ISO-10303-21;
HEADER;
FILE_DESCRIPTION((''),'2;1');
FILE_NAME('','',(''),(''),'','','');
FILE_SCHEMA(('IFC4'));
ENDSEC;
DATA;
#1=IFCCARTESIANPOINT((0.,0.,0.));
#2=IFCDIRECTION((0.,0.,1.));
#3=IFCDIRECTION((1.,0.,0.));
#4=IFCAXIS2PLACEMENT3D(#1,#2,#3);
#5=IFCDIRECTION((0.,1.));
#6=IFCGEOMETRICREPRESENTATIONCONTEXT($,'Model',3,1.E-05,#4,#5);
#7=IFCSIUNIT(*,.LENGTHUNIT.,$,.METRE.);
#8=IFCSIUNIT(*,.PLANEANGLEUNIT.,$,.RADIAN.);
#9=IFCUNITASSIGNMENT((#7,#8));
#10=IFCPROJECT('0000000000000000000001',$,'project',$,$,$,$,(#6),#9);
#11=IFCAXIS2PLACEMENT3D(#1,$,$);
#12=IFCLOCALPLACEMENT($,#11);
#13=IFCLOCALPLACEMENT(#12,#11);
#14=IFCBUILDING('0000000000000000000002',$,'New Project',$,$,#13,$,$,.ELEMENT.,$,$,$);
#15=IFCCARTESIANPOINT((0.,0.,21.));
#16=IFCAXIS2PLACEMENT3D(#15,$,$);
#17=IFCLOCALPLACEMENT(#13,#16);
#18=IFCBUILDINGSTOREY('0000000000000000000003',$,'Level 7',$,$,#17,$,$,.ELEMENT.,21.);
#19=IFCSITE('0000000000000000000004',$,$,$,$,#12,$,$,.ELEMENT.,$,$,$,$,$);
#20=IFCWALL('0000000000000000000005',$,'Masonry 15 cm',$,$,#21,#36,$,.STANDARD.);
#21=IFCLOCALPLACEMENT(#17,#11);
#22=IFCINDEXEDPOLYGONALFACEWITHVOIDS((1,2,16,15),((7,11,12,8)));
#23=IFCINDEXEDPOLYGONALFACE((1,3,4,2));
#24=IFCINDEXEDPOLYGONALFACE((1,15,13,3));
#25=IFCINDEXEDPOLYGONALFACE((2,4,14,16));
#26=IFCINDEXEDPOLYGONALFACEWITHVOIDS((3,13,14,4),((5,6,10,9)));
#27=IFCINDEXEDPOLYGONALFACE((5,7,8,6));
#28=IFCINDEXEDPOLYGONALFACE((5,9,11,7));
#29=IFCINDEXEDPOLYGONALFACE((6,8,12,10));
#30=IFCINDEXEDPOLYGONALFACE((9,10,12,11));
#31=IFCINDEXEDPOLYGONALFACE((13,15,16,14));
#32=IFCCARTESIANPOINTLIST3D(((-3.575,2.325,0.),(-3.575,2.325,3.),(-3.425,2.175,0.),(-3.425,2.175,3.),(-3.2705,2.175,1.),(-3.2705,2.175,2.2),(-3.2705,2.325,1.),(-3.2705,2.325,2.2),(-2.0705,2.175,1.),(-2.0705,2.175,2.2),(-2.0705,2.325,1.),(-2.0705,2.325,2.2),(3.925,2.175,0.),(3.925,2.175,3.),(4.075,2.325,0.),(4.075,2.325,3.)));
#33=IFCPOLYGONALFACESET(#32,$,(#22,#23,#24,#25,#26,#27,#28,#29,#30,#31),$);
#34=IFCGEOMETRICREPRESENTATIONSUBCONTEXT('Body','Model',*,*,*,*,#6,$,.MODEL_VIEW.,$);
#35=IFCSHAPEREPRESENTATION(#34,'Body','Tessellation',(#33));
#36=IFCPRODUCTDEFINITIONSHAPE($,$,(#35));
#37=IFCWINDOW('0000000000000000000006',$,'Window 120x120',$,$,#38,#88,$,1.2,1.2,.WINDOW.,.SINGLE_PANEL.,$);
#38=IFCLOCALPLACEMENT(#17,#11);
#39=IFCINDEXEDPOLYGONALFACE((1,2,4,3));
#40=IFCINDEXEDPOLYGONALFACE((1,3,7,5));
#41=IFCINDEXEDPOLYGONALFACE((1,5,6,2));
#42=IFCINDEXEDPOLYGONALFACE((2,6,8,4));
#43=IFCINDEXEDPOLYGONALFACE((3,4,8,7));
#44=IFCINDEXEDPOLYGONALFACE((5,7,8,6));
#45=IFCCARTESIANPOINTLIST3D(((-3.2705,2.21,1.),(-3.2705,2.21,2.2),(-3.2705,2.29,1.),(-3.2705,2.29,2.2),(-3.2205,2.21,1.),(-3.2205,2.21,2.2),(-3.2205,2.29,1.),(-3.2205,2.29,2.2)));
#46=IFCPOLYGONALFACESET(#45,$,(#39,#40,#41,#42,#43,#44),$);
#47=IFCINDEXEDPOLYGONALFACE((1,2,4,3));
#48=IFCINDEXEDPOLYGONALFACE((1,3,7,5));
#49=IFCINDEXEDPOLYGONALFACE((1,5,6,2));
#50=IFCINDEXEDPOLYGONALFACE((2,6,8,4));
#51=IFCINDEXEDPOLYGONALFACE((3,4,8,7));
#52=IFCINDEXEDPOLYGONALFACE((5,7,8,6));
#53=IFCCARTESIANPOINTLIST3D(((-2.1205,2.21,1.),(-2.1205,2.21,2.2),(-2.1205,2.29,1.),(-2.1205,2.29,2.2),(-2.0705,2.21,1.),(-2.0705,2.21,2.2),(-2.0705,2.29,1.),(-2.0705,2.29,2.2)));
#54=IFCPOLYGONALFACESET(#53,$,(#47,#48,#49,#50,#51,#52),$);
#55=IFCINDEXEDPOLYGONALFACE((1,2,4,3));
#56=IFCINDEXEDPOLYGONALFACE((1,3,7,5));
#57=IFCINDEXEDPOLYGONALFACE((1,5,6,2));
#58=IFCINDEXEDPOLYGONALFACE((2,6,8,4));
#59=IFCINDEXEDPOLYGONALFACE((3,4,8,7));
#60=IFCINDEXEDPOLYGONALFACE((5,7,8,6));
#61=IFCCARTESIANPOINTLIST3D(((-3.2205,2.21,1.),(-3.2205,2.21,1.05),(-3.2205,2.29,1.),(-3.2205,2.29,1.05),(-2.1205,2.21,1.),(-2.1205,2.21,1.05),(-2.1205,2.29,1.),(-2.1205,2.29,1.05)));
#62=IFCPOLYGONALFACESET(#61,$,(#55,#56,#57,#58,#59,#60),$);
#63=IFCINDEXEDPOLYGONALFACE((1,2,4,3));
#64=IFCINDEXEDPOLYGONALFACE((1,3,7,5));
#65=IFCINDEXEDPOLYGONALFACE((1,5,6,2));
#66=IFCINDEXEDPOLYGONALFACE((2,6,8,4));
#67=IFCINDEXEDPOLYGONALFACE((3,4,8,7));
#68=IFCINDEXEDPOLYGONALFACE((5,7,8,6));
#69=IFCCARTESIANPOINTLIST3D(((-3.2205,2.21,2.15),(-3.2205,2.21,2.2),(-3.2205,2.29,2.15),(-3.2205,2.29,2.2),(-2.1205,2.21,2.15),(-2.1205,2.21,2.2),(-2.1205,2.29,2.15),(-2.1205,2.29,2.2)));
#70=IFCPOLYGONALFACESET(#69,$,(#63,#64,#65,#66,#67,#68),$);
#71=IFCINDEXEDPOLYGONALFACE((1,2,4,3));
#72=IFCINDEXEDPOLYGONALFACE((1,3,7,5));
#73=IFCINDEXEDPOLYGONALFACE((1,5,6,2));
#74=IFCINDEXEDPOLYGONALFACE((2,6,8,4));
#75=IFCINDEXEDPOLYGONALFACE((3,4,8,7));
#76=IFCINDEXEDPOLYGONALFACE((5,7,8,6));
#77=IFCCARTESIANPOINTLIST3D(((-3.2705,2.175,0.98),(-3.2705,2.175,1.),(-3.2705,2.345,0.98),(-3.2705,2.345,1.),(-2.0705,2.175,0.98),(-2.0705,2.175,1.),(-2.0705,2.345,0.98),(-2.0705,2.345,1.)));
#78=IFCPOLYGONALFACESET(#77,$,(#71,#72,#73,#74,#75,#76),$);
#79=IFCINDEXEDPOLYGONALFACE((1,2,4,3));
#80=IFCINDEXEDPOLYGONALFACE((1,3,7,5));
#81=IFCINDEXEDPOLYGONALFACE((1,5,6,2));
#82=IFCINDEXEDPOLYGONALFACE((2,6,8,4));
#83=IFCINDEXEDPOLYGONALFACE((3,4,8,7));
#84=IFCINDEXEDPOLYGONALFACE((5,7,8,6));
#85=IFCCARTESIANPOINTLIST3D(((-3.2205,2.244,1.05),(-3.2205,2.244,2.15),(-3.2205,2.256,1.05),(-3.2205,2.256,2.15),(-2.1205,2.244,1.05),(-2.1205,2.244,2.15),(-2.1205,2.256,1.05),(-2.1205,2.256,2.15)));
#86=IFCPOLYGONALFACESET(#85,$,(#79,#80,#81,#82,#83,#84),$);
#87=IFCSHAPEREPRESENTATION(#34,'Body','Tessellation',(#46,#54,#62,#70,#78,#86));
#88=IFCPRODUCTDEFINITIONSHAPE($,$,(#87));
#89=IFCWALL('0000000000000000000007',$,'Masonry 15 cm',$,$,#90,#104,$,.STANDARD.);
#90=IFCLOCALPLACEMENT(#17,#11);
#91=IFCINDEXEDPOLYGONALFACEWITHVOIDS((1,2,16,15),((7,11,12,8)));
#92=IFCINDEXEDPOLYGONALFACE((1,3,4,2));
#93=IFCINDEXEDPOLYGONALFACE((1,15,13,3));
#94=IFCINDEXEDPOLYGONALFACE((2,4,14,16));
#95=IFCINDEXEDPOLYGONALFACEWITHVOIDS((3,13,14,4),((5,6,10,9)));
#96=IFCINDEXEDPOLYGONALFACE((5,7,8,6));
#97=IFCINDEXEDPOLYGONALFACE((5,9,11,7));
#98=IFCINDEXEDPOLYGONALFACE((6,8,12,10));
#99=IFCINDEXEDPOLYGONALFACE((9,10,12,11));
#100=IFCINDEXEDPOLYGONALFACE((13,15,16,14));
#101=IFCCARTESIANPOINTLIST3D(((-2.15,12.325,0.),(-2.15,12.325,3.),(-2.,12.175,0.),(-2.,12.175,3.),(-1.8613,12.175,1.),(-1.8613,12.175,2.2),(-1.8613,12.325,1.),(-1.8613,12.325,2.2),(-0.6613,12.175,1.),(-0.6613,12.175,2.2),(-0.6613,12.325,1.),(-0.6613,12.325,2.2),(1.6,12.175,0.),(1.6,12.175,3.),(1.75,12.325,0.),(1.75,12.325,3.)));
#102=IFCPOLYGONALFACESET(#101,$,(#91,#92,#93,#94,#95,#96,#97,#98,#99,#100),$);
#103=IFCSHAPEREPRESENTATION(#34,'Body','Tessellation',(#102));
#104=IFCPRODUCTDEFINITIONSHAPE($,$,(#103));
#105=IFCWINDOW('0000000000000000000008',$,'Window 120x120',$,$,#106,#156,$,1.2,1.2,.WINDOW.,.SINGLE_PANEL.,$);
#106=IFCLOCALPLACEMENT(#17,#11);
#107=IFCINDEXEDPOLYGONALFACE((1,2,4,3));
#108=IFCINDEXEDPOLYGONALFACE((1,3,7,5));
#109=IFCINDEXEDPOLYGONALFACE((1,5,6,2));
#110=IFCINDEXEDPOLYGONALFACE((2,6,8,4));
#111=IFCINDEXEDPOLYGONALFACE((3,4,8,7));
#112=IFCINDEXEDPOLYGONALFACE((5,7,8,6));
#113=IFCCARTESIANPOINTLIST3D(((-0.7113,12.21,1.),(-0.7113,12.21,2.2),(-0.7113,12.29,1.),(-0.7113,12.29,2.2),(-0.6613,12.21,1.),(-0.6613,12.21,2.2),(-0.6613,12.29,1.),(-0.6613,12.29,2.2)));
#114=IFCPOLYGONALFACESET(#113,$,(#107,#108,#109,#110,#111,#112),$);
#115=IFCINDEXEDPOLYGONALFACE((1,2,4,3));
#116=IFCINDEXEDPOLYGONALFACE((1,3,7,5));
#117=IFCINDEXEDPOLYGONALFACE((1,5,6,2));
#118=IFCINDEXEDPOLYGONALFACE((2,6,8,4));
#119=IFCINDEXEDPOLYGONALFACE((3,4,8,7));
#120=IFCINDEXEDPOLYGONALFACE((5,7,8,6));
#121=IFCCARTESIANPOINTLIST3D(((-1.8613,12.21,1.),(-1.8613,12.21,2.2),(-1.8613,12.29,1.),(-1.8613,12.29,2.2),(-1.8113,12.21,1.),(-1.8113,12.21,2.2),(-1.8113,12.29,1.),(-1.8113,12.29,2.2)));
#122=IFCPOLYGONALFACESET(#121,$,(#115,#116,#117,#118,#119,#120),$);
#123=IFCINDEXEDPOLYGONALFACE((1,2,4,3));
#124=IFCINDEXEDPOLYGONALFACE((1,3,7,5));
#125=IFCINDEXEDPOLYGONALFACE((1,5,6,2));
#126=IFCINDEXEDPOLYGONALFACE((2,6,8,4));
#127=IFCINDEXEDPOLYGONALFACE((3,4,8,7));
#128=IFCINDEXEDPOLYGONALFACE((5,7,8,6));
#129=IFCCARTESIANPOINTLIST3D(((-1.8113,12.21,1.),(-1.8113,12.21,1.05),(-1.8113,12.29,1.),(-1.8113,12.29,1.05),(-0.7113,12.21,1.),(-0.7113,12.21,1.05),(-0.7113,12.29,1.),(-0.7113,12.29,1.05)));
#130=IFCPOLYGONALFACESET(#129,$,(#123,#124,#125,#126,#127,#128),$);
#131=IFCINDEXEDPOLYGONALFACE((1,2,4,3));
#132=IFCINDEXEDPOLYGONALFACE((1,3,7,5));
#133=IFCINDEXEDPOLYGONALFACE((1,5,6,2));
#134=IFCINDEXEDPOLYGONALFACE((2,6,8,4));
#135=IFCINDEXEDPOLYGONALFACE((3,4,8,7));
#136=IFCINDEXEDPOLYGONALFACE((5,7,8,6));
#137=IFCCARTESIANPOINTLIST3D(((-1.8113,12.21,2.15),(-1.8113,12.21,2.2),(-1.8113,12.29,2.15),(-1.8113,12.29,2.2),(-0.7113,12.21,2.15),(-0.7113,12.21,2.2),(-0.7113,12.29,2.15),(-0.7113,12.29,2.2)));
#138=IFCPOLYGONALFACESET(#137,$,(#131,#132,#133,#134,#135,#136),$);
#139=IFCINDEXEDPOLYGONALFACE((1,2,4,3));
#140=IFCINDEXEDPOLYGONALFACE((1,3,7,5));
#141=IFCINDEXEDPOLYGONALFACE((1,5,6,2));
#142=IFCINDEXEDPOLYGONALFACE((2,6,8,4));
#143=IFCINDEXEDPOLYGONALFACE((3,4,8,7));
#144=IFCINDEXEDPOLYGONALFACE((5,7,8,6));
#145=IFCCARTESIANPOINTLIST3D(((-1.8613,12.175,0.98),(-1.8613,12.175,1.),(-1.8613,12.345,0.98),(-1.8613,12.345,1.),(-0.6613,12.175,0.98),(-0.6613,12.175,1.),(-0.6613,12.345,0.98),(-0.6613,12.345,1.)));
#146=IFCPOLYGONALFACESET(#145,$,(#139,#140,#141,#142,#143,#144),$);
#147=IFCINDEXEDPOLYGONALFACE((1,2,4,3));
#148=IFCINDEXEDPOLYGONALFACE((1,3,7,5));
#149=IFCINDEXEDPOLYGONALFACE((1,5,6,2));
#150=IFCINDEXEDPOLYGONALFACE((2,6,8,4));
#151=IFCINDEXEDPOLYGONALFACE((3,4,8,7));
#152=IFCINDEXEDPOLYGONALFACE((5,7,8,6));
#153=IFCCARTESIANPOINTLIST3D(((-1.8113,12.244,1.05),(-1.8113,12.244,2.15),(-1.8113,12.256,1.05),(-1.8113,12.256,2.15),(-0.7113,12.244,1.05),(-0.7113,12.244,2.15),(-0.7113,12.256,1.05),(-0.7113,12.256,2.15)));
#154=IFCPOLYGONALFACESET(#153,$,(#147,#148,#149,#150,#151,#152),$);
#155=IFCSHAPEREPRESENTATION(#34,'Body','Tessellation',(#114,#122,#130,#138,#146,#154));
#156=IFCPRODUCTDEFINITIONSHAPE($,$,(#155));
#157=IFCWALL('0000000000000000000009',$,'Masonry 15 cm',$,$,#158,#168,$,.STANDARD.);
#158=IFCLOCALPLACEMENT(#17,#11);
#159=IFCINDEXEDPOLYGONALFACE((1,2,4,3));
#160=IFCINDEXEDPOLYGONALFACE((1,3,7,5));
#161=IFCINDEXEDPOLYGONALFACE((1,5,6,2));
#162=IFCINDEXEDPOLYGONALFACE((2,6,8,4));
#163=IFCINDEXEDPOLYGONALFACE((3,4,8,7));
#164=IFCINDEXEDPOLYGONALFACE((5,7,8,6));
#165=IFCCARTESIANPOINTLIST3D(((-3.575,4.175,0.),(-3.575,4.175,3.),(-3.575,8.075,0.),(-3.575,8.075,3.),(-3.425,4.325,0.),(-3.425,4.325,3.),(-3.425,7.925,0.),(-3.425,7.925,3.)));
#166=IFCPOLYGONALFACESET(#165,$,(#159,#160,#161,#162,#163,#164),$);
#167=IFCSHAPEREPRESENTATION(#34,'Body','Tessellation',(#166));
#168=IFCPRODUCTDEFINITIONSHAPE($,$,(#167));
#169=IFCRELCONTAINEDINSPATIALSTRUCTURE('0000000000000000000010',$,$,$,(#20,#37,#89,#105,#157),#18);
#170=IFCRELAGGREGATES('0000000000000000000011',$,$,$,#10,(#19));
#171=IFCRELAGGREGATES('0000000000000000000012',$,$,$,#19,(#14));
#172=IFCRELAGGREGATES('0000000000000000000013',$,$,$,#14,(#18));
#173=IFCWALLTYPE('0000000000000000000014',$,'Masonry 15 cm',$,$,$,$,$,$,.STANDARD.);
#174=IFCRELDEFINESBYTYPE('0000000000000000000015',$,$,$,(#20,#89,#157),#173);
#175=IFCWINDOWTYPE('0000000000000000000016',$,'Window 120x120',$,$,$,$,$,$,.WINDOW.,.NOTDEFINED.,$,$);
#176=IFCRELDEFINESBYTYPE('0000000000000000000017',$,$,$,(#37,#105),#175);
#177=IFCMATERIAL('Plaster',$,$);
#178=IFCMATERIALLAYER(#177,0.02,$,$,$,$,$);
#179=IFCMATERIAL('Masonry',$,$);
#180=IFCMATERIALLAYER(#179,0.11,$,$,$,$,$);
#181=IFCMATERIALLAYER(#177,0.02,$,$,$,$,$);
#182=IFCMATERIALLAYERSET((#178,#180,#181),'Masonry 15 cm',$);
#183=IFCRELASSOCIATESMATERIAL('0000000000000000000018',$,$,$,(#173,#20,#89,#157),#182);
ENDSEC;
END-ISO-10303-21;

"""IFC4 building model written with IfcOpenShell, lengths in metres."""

from ifc_helpers import new_model, si_unit, direction, frame, frame_2d, origin, origin_with_axes, place, context, subcontext, project, spatial, polyline, rectangle, outline, extrude, material, layer, layer_set, layer_usage, type_object, element, fill, save


model = new_model("IFC4")

# Units and contexts
model_context = context("Model", 3, precision=1e-05, world=origin_with_axes(), true_north=direction((0.0, 1.0)))
body_context = subcontext(model_context, "Body", "Model", "MODEL_VIEW")
ifc_project = project(units=[si_unit("LENGTHUNIT", "METRE"), si_unit("PLANEANGLEUNIT", "RADIAN")], contexts=[model_context])

# Site, building, storey
site_placement = place(None, origin())
site = spatial("IfcSite", under=ifc_project, at=site_placement, CompositionType="ELEMENT")
building_placement = place(site_placement, origin())
building = spatial("IfcBuilding", under=site, at=building_placement, Name="New Project", CompositionType="ELEMENT")
storey_placement = place(building_placement, frame((0.0, 0.0, 21.0)))
storey = spatial("IfcBuildingStorey", under=building, at=storey_placement, Name="Level 7", CompositionType="ELEMENT", Elevation=21.0)

# Walls, openings, windows
ifc_material_1 = material(Name="Plaster")
ifc_layer_1 = layer(ifc_material_1, 0.02)
ifc_material_2 = material(Name="Masonry")
ifc_layer_2 = layer(ifc_material_2, 0.11)
ifc_layer_3 = layer(ifc_material_1, 0.02)
ifc_layer_set_1 = layer_set([ifc_layer_1, ifc_layer_2, ifc_layer_3], Name="Masonry 15 cm")
ifc_layer_usage_1 = layer_usage(ifc_layer_set_1, "AXIS2", "NEGATIVE", 0.075)
wall_type = type_object("IfcWallType", Name="Masonry 15 cm", PredefinedType="STANDARD", material=ifc_layer_set_1)
wall_1_placement = place(storey_placement, frame((-3.5, 2.25, 0.0)))
wall_1 = element("IfcWall", 1, at=wall_1_placement, inside=storey, type_object=wall_type, material=ifc_layer_usage_1, Name="Masonry 15 cm", PredefinedType="STANDARD", context=body_context, shape_type="SweptSolid", body=[
    extrude(outline(polyline([(0.075, -0.075), (7.425, -0.075), (7.575, 0.075), (-0.075, 0.075), (0.075, -0.075)])), origin(), (0.0, 0.0, 1.0), 3.0),
])
opening_1_placement = place(wall_1_placement, frame((0.2295, 0.0, 1.0)))
opening_1 = element("IfcOpeningElement", 2, at=opening_1_placement, cuts=wall_1, PredefinedType="OPENING", context=body_context, shape_type="SweptSolid", body=[
    extrude(rectangle(XDim=1.2, YDim=0.25, at=frame_2d((0.6, 0.0))), origin(), (0.0, 0.0, 1.0), 1.2),
])
window_type = type_object("IfcWindowType", Name="Window 120x120", PartitioningType="NOTDEFINED", PredefinedType="WINDOW")
window_1_placement = place(opening_1_placement, origin())
window_1 = element("IfcWindow", 3, at=window_1_placement, inside=storey, type_object=window_type, Name="Window 120x120", OverallHeight=1.2, OverallWidth=1.2, PartitioningType="SINGLE_PANEL", PredefinedType="WINDOW", context=body_context, shape_type="SweptSolid", body=[
    extrude(outline(polyline([(0.0, -0.04), (0.05, -0.04), (0.05, 0.04), (0.0, 0.04), (0.0, -0.04)])), origin(), (0.0, 0.0, 1.0), 1.2),
    extrude(outline(polyline([(1.15, -0.04), (1.2, -0.04), (1.2, 0.04), (1.15, 0.04), (1.15, -0.04)])), origin(), (0.0, 0.0, 1.0), 1.2),
    extrude(outline(polyline([(0.05, -0.04), (1.15, -0.04), (1.15, 0.04), (0.05, 0.04), (0.05, -0.04)])), origin(), (0.0, 0.0, 1.0), 0.05),
    extrude(outline(polyline([(0.05, -0.04), (1.15, -0.04), (1.15, 0.04), (0.05, 0.04), (0.05, -0.04)])), frame((0.0, 0.0, 1.15)), (0.0, 0.0, 1.0), 0.05),
    extrude(outline(polyline([(0.0, -0.075), (1.2, -0.075), (1.2, 0.095), (0.0, 0.095), (0.0, -0.075)])), frame((0.0, 0.0, -0.02)), (0.0, 0.0, 1.0), 0.02),
    extrude(outline(polyline([(0.05, -0.006), (1.15, -0.006), (1.15, 0.006), (0.05, 0.006), (0.05, -0.006)])), frame((0.0, 0.0, 0.05)), (0.0, 0.0, 1.0), 1.1),
])
fill(opening_1, window_1)
wall_2_placement = place(storey_placement, frame((-2.075, 12.25, 0.0)))
wall_2 = element("IfcWall", 4, at=wall_2_placement, inside=storey, type_object=wall_type, material=ifc_layer_usage_1, Name="Masonry 15 cm", PredefinedType="STANDARD", context=body_context, shape_type="SweptSolid", body=[
    extrude(outline(polyline([(0.075, -0.075), (3.675, -0.075), (3.825, 0.075), (-0.075, 0.075), (0.075, -0.075)])), origin(), (0.0, 0.0, 1.0), 3.0),
])
opening_2_placement = place(wall_2_placement, frame((0.2137, 0.0, 1.0)))
opening_2 = element("IfcOpeningElement", 5, at=opening_2_placement, cuts=wall_2, PredefinedType="OPENING", context=body_context, shape_type="SweptSolid", body=[
    extrude(rectangle(XDim=1.2, YDim=0.25, at=frame_2d((0.6, 0.0))), origin(), (0.0, 0.0, 1.0), 1.2),
])
window_2_placement = place(opening_2_placement, origin())
window_2 = element("IfcWindow", 6, at=window_2_placement, inside=storey, type_object=window_type, Name="Window 120x120", OverallHeight=1.2, OverallWidth=1.2, PartitioningType="SINGLE_PANEL", PredefinedType="WINDOW", context=body_context, shape_type="SweptSolid", body=[
    extrude(outline(polyline([(1.2, 0.04), (1.15, 0.04), (1.15, -0.04), (1.2, -0.04), (1.2, 0.04)])), origin(), (0.0, 0.0, 1.0), 1.2),
    extrude(outline(polyline([(0.05, 0.04), (0.0, 0.04), (0.0, -0.04), (0.05, -0.04), (0.05, 0.04)])), origin(), (0.0, 0.0, 1.0), 1.2),
    extrude(outline(polyline([(1.15, 0.04), (0.05, 0.04), (0.05, -0.04), (1.15, -0.04), (1.15, 0.04)])), origin(), (0.0, 0.0, 1.0), 0.05),
    extrude(outline(polyline([(1.15, 0.04), (0.05, 0.04), (0.05, -0.04), (1.15, -0.04), (1.15, 0.04)])), frame((0.0, 0.0, 1.15)), (0.0, 0.0, 1.0), 0.05),
    extrude(outline(polyline([(1.2, 0.095), (0.0, 0.095), (0.0, -0.075), (1.2, -0.075), (1.2, 0.095)])), frame((0.0, 0.0, -0.02)), (0.0, 0.0, 1.0), 0.02),
    extrude(outline(polyline([(1.15, 0.006), (0.05, 0.006), (0.05, -0.006), (1.15, -0.006), (1.15, 0.006)])), frame((0.0, 0.0, 0.05)), (0.0, 0.0, 1.0), 1.1),
])
fill(opening_2, window_2)

# Wall
wall_3_placement = place(storey_placement, frame((-3.5, 4.25, 0.0), z_axis=(0.0, 0.0, 1.0), x_axis=(0.0, 1.0, 0.0)))
element("IfcWall", 7, at=wall_3_placement, inside=storey, type_object=wall_type, material=ifc_layer_usage_1, Name="Masonry 15 cm", PredefinedType="STANDARD", context=body_context, shape_type="SweptSolid", body=[
    extrude(outline(polyline([(0.075, -0.075), (3.675, -0.075), (3.825, 0.075), (-0.075, 0.075), (0.075, -0.075)])), origin(), (0.0, 0.0, 1.0), 3.0),
])

save(model, "model.ifc")
